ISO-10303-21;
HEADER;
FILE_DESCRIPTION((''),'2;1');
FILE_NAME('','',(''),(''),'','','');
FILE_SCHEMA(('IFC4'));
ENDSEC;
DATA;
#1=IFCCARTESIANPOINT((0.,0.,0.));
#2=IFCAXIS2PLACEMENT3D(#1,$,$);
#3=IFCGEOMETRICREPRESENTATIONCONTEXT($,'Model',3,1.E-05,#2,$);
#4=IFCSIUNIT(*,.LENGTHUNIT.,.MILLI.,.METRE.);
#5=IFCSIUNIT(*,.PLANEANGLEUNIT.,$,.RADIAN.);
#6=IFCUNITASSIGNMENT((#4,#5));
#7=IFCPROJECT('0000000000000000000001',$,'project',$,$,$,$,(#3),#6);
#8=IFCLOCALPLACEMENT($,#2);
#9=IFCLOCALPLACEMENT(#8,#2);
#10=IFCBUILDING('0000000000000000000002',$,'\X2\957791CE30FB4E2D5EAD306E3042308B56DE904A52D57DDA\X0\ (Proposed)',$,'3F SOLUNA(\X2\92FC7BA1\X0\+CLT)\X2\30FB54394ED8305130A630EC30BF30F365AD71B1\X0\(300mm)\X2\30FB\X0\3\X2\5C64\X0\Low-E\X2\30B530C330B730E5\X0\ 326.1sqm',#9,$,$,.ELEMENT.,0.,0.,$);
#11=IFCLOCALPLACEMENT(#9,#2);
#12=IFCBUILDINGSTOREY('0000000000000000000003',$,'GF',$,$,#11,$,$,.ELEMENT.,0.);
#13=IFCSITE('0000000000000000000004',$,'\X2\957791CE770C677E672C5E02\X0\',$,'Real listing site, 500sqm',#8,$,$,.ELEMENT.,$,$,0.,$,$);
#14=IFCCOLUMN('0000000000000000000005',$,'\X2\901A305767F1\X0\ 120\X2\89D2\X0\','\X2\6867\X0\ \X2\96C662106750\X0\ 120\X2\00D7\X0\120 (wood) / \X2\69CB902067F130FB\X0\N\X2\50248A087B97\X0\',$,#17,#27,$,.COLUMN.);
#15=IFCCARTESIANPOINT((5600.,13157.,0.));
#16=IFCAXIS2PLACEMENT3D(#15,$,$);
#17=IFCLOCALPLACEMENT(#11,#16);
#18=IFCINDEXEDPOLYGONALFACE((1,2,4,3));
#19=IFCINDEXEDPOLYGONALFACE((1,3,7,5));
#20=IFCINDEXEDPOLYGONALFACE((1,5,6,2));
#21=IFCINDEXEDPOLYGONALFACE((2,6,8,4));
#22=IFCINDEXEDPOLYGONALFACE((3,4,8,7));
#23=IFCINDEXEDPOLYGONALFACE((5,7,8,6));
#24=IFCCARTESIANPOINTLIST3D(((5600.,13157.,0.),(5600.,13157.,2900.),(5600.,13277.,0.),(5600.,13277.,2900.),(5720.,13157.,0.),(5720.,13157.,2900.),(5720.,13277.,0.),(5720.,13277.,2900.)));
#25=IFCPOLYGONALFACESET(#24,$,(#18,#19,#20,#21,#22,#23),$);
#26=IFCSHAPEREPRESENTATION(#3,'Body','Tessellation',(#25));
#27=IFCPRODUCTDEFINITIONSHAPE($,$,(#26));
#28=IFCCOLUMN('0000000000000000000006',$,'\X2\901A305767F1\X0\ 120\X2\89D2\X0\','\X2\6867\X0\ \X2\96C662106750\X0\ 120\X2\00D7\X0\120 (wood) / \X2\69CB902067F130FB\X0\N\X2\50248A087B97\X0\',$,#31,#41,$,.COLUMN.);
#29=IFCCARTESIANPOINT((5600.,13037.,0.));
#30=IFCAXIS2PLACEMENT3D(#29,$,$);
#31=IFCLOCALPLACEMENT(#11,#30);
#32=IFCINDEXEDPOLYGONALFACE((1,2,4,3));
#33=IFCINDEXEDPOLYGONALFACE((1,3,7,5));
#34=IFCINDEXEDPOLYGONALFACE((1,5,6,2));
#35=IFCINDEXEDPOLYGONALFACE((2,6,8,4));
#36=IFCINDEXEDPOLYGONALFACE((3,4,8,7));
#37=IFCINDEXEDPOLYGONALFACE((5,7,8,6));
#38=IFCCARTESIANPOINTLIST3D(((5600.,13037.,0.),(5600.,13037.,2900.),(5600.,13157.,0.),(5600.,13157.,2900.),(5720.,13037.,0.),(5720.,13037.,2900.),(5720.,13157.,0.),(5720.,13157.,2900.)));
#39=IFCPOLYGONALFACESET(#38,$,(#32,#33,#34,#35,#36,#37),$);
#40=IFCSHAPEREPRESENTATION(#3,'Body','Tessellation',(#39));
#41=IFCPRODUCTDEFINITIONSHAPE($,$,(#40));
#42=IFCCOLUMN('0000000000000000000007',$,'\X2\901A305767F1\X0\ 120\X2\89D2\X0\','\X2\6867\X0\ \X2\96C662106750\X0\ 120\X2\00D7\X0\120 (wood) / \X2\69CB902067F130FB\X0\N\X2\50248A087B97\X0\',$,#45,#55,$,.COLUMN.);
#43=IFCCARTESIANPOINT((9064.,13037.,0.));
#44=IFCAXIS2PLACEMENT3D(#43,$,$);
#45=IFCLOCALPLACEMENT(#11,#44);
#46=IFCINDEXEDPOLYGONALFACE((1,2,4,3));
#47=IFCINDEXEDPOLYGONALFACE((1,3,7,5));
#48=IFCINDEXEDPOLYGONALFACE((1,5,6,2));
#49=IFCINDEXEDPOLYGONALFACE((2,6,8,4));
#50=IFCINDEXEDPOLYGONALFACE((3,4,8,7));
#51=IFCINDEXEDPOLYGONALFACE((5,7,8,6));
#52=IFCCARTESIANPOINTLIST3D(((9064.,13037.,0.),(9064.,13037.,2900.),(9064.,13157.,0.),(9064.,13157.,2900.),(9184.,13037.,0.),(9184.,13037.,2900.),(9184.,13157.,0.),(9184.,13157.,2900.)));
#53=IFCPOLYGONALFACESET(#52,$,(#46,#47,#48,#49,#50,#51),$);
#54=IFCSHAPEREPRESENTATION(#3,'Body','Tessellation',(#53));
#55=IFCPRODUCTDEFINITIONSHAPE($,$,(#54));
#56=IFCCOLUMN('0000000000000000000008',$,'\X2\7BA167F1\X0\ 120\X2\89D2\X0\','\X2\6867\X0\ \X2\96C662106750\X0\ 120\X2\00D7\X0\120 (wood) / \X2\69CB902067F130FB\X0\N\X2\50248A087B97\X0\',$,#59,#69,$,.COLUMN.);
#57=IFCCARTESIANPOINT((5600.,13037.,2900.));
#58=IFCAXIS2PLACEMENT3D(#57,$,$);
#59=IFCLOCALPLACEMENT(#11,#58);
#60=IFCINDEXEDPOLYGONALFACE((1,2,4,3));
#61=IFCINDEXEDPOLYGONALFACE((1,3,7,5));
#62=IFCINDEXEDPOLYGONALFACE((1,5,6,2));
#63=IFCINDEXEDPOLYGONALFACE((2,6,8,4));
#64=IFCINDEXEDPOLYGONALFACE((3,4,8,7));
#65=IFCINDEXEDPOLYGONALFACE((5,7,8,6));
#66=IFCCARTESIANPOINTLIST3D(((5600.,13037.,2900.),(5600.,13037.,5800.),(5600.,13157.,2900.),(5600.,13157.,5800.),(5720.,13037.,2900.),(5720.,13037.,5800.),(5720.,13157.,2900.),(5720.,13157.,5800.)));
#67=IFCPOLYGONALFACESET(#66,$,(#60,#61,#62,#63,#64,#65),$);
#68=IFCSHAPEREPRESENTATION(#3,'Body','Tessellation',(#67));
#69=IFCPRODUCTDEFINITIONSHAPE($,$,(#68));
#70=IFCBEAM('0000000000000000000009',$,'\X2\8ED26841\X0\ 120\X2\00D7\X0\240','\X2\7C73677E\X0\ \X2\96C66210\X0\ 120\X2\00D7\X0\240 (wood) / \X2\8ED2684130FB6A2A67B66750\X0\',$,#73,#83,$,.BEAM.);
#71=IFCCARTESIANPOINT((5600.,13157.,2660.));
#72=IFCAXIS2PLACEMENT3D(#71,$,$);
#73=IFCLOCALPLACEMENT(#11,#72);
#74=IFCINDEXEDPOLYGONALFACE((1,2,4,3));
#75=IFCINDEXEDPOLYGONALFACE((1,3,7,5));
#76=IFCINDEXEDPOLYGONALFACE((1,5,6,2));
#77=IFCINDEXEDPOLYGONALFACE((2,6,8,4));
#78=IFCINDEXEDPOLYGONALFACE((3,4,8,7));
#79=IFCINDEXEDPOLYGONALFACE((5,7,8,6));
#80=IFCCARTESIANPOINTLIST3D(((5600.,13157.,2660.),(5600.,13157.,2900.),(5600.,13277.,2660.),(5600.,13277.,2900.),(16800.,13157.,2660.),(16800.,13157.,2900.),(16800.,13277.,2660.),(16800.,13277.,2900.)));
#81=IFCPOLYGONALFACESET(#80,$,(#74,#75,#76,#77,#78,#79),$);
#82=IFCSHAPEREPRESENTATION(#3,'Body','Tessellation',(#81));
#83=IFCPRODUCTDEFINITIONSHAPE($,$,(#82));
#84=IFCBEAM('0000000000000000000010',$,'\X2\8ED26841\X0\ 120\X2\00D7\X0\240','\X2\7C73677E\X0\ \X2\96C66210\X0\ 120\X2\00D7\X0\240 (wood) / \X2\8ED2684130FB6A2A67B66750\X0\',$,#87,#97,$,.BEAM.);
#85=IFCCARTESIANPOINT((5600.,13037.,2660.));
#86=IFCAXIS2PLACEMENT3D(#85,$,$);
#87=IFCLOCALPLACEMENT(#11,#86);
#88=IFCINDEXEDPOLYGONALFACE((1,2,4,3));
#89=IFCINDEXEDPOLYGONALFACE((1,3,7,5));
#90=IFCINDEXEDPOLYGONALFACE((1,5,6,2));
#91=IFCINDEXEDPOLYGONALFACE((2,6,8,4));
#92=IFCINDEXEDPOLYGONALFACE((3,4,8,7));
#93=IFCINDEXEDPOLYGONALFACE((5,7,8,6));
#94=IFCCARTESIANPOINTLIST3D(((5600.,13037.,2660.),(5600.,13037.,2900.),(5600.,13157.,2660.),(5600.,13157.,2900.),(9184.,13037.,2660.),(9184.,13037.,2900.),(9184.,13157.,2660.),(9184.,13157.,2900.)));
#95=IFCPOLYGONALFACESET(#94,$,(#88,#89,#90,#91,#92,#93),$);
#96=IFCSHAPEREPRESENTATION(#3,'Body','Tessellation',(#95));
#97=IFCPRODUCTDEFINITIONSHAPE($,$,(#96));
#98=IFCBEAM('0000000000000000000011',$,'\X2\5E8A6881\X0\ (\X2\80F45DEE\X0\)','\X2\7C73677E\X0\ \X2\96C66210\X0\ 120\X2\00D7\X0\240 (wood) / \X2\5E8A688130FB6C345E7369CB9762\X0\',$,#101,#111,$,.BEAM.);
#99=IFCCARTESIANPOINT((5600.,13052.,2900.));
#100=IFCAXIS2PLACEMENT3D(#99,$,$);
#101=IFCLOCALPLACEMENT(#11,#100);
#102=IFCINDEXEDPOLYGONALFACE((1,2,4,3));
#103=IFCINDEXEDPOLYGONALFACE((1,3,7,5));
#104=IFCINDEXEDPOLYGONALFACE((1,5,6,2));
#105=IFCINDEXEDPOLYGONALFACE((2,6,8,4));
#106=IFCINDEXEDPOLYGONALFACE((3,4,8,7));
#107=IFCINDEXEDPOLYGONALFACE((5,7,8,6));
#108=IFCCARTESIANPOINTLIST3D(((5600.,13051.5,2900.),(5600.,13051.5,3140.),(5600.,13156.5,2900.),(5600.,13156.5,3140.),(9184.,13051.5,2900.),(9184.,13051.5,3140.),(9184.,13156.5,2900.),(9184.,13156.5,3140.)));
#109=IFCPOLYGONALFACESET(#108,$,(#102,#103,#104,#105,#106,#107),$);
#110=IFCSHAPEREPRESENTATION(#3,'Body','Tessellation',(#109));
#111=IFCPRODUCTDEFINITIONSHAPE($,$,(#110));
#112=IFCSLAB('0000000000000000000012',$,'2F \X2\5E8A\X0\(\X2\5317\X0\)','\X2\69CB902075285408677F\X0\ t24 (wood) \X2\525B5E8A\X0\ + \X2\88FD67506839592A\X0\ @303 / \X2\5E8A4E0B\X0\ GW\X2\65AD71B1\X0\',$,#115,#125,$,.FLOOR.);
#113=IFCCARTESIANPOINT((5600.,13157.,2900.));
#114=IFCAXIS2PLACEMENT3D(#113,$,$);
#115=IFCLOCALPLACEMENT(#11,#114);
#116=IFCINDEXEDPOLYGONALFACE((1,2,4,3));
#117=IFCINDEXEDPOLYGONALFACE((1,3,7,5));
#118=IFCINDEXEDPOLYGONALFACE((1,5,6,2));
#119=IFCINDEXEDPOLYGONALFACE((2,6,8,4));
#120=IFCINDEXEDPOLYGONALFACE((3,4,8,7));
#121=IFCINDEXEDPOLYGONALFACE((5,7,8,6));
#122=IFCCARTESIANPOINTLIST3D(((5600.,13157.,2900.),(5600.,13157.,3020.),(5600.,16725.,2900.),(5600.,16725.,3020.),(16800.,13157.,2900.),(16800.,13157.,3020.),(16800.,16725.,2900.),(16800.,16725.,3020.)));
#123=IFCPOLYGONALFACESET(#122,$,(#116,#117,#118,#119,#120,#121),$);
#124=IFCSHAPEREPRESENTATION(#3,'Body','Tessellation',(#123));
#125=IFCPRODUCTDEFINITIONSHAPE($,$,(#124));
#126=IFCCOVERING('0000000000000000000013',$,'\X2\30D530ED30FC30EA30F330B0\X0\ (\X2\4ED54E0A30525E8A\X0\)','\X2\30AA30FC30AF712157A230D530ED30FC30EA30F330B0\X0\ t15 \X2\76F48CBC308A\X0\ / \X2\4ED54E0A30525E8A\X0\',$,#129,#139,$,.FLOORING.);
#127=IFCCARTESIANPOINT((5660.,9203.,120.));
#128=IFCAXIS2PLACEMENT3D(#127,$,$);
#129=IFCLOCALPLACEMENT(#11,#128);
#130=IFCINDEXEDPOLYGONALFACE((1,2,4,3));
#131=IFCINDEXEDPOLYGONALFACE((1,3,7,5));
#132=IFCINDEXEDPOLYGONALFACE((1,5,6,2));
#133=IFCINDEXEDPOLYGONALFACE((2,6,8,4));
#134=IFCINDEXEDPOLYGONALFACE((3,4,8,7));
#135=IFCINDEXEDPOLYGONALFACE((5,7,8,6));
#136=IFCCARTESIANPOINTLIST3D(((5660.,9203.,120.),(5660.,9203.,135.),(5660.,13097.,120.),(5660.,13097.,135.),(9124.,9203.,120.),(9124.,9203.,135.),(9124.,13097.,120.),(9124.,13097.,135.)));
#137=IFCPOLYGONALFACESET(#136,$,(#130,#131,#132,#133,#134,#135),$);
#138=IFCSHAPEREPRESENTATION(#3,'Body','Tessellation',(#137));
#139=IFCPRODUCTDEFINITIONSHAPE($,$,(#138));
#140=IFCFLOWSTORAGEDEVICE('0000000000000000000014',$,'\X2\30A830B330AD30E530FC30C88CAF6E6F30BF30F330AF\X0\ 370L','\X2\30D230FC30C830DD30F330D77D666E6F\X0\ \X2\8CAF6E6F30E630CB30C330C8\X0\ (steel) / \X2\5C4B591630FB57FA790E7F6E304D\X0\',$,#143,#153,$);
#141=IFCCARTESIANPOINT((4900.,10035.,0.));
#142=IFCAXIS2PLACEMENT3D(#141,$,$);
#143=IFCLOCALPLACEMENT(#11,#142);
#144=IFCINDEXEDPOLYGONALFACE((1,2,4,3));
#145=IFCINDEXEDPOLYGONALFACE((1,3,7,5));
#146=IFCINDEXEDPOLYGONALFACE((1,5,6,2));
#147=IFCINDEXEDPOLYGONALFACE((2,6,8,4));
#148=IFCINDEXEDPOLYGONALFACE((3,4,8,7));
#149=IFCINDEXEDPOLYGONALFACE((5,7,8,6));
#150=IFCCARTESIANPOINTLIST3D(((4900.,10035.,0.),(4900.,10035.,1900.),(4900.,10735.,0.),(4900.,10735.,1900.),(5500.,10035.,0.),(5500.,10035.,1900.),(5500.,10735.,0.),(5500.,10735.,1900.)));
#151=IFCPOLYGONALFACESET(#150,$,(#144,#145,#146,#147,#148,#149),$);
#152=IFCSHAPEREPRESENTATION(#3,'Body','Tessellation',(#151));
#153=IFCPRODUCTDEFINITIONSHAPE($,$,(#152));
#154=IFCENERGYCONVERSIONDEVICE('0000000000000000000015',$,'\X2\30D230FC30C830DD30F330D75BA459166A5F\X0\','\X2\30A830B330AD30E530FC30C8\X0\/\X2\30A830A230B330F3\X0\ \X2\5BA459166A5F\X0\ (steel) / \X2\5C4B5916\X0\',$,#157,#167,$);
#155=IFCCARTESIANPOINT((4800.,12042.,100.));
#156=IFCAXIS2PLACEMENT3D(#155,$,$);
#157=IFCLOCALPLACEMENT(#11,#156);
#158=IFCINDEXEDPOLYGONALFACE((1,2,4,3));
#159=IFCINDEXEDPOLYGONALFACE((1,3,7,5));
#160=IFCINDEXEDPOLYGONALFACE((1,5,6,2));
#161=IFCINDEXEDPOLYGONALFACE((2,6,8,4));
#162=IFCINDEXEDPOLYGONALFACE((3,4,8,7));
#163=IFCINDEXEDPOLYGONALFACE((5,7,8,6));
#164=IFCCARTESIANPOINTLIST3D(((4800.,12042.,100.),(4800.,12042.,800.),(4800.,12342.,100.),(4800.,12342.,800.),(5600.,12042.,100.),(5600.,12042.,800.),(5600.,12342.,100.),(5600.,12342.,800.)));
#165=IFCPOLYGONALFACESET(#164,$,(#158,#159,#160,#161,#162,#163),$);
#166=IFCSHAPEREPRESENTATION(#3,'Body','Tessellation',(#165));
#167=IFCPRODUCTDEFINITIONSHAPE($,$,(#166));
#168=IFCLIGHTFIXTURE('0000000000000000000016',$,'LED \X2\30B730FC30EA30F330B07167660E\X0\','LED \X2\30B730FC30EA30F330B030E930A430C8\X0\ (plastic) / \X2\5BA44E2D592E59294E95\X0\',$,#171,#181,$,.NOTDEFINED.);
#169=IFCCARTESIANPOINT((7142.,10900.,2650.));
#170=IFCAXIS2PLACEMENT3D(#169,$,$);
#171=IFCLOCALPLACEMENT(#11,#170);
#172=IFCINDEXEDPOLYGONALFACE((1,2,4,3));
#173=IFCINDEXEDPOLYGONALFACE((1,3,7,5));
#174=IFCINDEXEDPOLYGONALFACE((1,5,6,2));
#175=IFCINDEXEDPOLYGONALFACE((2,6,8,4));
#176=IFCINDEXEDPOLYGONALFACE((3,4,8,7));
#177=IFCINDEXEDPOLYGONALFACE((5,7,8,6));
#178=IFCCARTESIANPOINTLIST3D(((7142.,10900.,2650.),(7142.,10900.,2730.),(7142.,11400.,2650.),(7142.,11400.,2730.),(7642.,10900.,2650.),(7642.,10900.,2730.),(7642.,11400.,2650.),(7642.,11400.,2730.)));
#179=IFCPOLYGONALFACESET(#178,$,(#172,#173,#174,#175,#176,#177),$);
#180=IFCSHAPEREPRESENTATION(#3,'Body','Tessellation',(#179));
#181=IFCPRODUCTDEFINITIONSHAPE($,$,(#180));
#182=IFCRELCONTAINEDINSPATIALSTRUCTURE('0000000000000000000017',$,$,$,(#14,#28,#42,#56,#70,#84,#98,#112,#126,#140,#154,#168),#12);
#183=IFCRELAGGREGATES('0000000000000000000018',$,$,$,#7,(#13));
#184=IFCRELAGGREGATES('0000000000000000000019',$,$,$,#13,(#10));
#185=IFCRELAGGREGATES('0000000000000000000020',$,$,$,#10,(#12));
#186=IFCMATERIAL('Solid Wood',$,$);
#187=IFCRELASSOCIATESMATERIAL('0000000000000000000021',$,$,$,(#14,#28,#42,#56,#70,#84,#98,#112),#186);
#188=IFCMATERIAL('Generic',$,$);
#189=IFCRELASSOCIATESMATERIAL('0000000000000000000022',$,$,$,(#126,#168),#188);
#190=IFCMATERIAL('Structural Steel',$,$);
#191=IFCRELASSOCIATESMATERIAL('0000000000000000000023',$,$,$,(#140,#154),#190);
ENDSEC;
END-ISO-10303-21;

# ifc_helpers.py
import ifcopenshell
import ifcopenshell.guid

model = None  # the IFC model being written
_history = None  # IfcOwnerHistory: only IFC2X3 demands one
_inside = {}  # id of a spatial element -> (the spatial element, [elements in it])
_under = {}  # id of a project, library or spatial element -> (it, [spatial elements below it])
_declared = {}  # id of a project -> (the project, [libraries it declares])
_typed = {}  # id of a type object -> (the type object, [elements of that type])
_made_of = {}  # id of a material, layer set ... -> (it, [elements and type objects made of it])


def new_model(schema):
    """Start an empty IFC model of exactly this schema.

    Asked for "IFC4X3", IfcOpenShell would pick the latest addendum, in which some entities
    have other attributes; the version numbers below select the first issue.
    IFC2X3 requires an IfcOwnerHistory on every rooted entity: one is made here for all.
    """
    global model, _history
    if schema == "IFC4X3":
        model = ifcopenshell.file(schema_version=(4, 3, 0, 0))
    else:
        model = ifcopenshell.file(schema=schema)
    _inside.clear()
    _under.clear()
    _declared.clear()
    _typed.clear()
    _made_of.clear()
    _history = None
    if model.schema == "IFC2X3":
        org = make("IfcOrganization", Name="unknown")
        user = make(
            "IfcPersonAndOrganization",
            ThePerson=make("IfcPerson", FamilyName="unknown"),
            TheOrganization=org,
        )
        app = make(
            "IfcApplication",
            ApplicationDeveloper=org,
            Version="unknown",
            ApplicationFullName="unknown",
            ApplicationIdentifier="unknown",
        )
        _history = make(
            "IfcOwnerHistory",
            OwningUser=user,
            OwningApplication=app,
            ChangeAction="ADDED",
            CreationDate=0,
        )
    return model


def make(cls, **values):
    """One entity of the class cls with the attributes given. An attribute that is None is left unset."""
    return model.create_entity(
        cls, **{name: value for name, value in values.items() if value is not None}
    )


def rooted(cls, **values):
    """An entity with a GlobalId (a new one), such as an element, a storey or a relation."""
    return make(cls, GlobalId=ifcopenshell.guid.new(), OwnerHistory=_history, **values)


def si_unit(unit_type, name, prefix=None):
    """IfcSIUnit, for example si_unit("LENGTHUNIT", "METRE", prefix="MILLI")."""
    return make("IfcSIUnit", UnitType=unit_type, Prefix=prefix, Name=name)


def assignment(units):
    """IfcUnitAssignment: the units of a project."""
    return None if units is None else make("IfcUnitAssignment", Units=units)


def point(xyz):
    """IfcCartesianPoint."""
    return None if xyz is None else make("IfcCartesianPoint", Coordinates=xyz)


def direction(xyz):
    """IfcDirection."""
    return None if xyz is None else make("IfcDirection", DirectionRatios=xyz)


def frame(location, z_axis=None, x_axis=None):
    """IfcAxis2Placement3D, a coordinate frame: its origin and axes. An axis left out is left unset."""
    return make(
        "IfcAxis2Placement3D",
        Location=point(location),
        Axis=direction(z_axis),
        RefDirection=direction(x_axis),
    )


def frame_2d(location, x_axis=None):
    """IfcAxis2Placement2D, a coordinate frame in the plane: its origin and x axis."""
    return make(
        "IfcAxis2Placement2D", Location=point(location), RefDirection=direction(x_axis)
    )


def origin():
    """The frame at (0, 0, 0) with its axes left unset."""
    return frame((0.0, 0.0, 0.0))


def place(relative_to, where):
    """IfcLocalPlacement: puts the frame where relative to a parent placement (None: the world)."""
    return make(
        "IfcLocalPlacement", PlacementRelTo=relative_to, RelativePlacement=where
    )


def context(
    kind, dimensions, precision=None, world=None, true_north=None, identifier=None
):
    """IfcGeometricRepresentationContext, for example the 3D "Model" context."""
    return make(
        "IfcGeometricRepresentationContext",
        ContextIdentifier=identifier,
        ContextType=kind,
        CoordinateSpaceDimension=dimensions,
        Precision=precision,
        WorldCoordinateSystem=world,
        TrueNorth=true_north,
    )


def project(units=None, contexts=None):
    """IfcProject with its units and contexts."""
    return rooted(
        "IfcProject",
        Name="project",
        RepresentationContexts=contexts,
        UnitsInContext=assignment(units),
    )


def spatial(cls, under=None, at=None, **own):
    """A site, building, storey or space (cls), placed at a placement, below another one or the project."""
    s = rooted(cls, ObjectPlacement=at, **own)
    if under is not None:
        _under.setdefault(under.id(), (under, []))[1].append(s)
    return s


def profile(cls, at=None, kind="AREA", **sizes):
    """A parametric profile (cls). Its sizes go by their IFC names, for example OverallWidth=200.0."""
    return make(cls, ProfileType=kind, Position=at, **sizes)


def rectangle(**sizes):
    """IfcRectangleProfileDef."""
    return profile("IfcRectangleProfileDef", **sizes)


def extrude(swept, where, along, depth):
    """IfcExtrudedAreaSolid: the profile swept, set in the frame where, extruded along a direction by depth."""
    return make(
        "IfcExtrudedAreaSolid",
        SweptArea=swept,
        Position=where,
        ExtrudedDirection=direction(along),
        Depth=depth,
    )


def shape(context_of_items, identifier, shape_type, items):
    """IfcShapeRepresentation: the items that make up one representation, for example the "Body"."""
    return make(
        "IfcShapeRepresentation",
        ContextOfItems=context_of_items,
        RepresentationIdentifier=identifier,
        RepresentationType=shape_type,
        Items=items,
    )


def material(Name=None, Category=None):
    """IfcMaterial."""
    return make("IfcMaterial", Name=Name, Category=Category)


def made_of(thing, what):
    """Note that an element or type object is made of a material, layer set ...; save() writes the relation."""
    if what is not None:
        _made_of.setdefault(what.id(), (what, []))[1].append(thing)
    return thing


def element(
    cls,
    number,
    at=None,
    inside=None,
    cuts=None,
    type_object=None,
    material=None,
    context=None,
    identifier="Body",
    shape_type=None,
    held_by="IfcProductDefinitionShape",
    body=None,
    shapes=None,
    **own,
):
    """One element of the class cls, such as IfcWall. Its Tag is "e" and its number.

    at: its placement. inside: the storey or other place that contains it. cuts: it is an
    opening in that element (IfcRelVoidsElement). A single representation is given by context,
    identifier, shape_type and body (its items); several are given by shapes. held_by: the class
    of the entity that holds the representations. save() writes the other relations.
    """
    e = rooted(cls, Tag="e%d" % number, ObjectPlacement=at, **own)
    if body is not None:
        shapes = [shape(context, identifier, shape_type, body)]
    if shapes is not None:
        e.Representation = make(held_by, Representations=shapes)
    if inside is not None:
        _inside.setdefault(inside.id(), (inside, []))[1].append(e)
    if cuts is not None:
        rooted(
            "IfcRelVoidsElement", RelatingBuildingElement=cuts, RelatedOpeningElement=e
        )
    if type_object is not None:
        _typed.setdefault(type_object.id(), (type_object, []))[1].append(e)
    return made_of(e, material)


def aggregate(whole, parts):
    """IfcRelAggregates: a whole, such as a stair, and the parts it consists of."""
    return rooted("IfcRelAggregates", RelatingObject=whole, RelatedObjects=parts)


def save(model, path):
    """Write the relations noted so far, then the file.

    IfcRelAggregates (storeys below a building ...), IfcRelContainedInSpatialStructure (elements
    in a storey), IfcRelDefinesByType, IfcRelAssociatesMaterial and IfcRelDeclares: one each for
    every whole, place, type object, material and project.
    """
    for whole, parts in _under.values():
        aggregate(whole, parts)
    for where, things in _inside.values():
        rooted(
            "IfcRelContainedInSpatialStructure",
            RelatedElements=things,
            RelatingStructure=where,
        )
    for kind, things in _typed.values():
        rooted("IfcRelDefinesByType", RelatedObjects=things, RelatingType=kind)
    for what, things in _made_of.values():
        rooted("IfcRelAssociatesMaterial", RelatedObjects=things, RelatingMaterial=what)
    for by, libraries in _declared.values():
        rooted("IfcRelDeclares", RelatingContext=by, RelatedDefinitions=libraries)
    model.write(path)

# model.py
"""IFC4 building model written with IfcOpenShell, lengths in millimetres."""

from ifc_helpers import new_model, si_unit, frame, frame_2d, origin, place, context, project, spatial, rectangle, extrude, material, element, save


model = new_model("IFC4")

# Units and contexts
model_context = context("Model", 3, precision=1e-05, world=origin())
ifc_project = project(units=[si_unit("LENGTHUNIT", "METRE", prefix="MILLI"), si_unit("PLANEANGLEUNIT", "RADIAN")], contexts=[model_context])

# Site, building, storey
site_placement = place(None, origin())
site = spatial("IfcSite", under=ifc_project, at=site_placement, Name="長野県松本市", ObjectType="Real listing site, 500sqm", CompositionType="ELEMENT", RefElevation=0.0)
building_placement = place(site_placement, origin())
building = spatial("IfcBuilding", under=site, at=building_placement, Name="長野・中庭のある回遊動線 (Proposed)", ObjectType="3F SOLUNA(鋼管+CLT)・吹付けウレタン断熱(300mm)・3層Low-Eサッシュ 326.1sqm", CompositionType="ELEMENT", ElevationOfRefHeight=0.0, ElevationOfTerrain=0.0)
storey_placement = place(building_placement, origin())
storey = spatial("IfcBuildingStorey", under=building, at=storey_placement, Name="GF", CompositionType="ELEMENT", Elevation=0.0)

# Columns
ifc_material_1 = material(Name="Solid Wood")
column_1_placement = place(storey_placement, frame((5600.0, 13157.0, 0.0)))
element("IfcColumn", 1, at=column_1_placement, inside=storey, material=ifc_material_1, Name="通し柱 120角", Description="桧 集成材 120×120 (wood) / 構造柱・N値計算", PredefinedType="COLUMN", context=model_context, shape_type="SweptSolid", body=[
    extrude(rectangle(XDim=120.0, YDim=120.0, at=frame_2d((60.0, 60.0))), frame((5600.0, 13157.0, 0.0)), (0.0, 0.0, 1.0), 2900.0),
])
column_2_placement = place(storey_placement, frame((5600.0, 13037.0, 0.0)))
element("IfcColumn", 2, at=column_2_placement, inside=storey, material=ifc_material_1, Name="通し柱 120角", Description="桧 集成材 120×120 (wood) / 構造柱・N値計算", PredefinedType="COLUMN", context=model_context, shape_type="SweptSolid", body=[
    extrude(rectangle(XDim=120.0, YDim=120.0, at=frame_2d((60.0, 60.0))), frame((5600.0, 13037.0, 0.0)), (0.0, 0.0, 1.0), 2900.0),
])
column_3_placement = place(storey_placement, frame((9064.0, 13037.0, 0.0)))
element("IfcColumn", 3, at=column_3_placement, inside=storey, material=ifc_material_1, Name="通し柱 120角", Description="桧 集成材 120×120 (wood) / 構造柱・N値計算", PredefinedType="COLUMN", context=model_context, shape_type="SweptSolid", body=[
    extrude(rectangle(XDim=120.0, YDim=120.0, at=frame_2d((60.0, 60.0))), frame((9064.0, 13037.0, 0.0)), (0.0, 0.0, 1.0), 2900.0),
])
column_4_placement = place(storey_placement, frame((5600.0, 13037.0, 2900.0)))
element("IfcColumn", 4, at=column_4_placement, inside=storey, material=ifc_material_1, Name="管柱 120角", Description="桧 集成材 120×120 (wood) / 構造柱・N値計算", PredefinedType="COLUMN", context=model_context, shape_type="SweptSolid", body=[
    extrude(rectangle(XDim=120.0, YDim=120.0, at=frame_2d((60.0, 60.0))), frame((5600.0, 13037.0, 2900.0)), (0.0, 0.0, 1.0), 2900.0),
])

# Beams
beam_1_placement = place(storey_placement, frame((5600.0, 13157.0, 2660.0)))
element("IfcBeam", 5, at=beam_1_placement, inside=storey, material=ifc_material_1, Name="軒桁 120×240", Description="米松 集成 120×240 (wood) / 軒桁・横架材", PredefinedType="BEAM", context=model_context, shape_type="SweptSolid", body=[
    extrude(rectangle(XDim=11200.0, YDim=120.0, at=frame_2d((5600.0, 60.0))), frame((5600.0, 13157.0, 2660.0)), (0.0, 0.0, 1.0), 240.0),
])
beam_2_placement = place(storey_placement, frame((5600.0, 13037.0, 2660.0)))
element("IfcBeam", 6, at=beam_2_placement, inside=storey, material=ifc_material_1, Name="軒桁 120×240", Description="米松 集成 120×240 (wood) / 軒桁・横架材", PredefinedType="BEAM", context=model_context, shape_type="SweptSolid", body=[
    extrude(rectangle(XDim=3584.0, YDim=120.0, at=frame_2d((1792.0, 60.0))), frame((5600.0, 13037.0, 2660.0)), (0.0, 0.0, 1.0), 240.0),
])
beam_3_placement = place(storey_placement, frame((5600.0, 13052.0, 2900.0)))
element("IfcBeam", 7, at=beam_3_placement, inside=storey, material=ifc_material_1, Name="床梁 (胴差)", Description="米松 集成 120×240 (wood) / 床梁・水平構面", PredefinedType="BEAM", context=model_context, shape_type="SweptSolid", body=[
    extrude(rectangle(XDim=3584.0, YDim=105.0, at=frame_2d((1792.0, 52.0))), frame((5600.0, 13052.0, 2900.0)), (0.0, 0.0, 1.0), 240.0),
])

# Slab
slab_1_placement = place(storey_placement, frame((5600.0, 13157.0, 2900.0)))
element("IfcSlab", 8, at=slab_1_placement, inside=storey, material=ifc_material_1, Name="2F 床(北)", Description="構造用合板 t24 (wood) 剛床 + 製材根太 @303 / 床下 GW断熱", PredefinedType="FLOOR", context=model_context, shape_type="SweptSolid", body=[
    extrude(rectangle(XDim=11200.0, YDim=3568.0, at=frame_2d((5600.0, 1784.0))), frame((5600.0, 13157.0, 2900.0)), (0.0, 0.0, 1.0), 120.0),
])

# Covering
ifc_material_2 = material(Name="Generic")
covering_placement = place(storey_placement, frame((5660.0, 9203.0, 120.0)))
element("IfcCovering", 9, at=covering_placement, inside=storey, material=ifc_material_2, Name="フローリング (仕上げ床)", Description="オーク無垢フローリング t15 直貼り / 仕上げ床", PredefinedType="FLOORING", context=model_context, shape_type="SweptSolid", body=[
    extrude(rectangle(XDim=3464.0, YDim=3894.0, at=frame_2d((1732.0, 1947.0))), frame((5660.0, 9203.0, 120.0)), (0.0, 0.0, 1.0), 15.0),
])

# Flow storage device
ifc_material_3 = material(Name="Structural Steel")
flow_storage_device_placement = place(storey_placement, frame((4900.0, 10035.0, 0.0)))
element("IfcFlowStorageDevice", 10, at=flow_storage_device_placement, inside=storey, material=ifc_material_3, Name="エコキュート貯湯タンク 370L", Description="ヒートポンプ給湯 貯湯ユニット (steel) / 屋外・基礎置き", context=model_context, shape_type="SweptSolid", body=[
    extrude(rectangle(XDim=600.0, YDim=700.0, at=frame_2d((300.0, 350.0))), frame((4900.0, 10035.0, 0.0)), (0.0, 0.0, 1.0), 1900.0),
])

# Energy conversion device
energy_conversion_device_placement = place(storey_placement, frame((4800.0, 12042.0, 100.0)))
element("IfcEnergyConversionDevice", 11, at=energy_conversion_device_placement, inside=storey, material=ifc_material_3, Name="ヒートポンプ室外機", Description="エコキュート/エアコン 室外機 (steel) / 屋外", context=model_context, shape_type="SweptSolid", body=[
    extrude(rectangle(XDim=800.0, YDim=300.0, at=frame_2d((400.0, 150.0))), frame((4800.0, 12042.0, 100.0)), (0.0, 0.0, 1.0), 700.0),
])

# Light fixture
light_fixture_placement = place(storey_placement, frame((7142.0, 10900.0, 2650.0)))
element("IfcLightFixture", 12, at=light_fixture_placement, inside=storey, material=ifc_material_2, Name="LED シーリング照明", Description="LED シーリングライト (plastic) / 室中央天井", PredefinedType="NOTDEFINED", context=model_context, shape_type="SweptSolid", body=[
    extrude(rectangle(XDim=500.0, YDim=500.0, at=frame_2d((250.0, 250.0))), frame((7142.0, 10900.0, 2650.0)), (0.0, 0.0, 1.0), 80.0),
])

save(model, "model.ifc")
